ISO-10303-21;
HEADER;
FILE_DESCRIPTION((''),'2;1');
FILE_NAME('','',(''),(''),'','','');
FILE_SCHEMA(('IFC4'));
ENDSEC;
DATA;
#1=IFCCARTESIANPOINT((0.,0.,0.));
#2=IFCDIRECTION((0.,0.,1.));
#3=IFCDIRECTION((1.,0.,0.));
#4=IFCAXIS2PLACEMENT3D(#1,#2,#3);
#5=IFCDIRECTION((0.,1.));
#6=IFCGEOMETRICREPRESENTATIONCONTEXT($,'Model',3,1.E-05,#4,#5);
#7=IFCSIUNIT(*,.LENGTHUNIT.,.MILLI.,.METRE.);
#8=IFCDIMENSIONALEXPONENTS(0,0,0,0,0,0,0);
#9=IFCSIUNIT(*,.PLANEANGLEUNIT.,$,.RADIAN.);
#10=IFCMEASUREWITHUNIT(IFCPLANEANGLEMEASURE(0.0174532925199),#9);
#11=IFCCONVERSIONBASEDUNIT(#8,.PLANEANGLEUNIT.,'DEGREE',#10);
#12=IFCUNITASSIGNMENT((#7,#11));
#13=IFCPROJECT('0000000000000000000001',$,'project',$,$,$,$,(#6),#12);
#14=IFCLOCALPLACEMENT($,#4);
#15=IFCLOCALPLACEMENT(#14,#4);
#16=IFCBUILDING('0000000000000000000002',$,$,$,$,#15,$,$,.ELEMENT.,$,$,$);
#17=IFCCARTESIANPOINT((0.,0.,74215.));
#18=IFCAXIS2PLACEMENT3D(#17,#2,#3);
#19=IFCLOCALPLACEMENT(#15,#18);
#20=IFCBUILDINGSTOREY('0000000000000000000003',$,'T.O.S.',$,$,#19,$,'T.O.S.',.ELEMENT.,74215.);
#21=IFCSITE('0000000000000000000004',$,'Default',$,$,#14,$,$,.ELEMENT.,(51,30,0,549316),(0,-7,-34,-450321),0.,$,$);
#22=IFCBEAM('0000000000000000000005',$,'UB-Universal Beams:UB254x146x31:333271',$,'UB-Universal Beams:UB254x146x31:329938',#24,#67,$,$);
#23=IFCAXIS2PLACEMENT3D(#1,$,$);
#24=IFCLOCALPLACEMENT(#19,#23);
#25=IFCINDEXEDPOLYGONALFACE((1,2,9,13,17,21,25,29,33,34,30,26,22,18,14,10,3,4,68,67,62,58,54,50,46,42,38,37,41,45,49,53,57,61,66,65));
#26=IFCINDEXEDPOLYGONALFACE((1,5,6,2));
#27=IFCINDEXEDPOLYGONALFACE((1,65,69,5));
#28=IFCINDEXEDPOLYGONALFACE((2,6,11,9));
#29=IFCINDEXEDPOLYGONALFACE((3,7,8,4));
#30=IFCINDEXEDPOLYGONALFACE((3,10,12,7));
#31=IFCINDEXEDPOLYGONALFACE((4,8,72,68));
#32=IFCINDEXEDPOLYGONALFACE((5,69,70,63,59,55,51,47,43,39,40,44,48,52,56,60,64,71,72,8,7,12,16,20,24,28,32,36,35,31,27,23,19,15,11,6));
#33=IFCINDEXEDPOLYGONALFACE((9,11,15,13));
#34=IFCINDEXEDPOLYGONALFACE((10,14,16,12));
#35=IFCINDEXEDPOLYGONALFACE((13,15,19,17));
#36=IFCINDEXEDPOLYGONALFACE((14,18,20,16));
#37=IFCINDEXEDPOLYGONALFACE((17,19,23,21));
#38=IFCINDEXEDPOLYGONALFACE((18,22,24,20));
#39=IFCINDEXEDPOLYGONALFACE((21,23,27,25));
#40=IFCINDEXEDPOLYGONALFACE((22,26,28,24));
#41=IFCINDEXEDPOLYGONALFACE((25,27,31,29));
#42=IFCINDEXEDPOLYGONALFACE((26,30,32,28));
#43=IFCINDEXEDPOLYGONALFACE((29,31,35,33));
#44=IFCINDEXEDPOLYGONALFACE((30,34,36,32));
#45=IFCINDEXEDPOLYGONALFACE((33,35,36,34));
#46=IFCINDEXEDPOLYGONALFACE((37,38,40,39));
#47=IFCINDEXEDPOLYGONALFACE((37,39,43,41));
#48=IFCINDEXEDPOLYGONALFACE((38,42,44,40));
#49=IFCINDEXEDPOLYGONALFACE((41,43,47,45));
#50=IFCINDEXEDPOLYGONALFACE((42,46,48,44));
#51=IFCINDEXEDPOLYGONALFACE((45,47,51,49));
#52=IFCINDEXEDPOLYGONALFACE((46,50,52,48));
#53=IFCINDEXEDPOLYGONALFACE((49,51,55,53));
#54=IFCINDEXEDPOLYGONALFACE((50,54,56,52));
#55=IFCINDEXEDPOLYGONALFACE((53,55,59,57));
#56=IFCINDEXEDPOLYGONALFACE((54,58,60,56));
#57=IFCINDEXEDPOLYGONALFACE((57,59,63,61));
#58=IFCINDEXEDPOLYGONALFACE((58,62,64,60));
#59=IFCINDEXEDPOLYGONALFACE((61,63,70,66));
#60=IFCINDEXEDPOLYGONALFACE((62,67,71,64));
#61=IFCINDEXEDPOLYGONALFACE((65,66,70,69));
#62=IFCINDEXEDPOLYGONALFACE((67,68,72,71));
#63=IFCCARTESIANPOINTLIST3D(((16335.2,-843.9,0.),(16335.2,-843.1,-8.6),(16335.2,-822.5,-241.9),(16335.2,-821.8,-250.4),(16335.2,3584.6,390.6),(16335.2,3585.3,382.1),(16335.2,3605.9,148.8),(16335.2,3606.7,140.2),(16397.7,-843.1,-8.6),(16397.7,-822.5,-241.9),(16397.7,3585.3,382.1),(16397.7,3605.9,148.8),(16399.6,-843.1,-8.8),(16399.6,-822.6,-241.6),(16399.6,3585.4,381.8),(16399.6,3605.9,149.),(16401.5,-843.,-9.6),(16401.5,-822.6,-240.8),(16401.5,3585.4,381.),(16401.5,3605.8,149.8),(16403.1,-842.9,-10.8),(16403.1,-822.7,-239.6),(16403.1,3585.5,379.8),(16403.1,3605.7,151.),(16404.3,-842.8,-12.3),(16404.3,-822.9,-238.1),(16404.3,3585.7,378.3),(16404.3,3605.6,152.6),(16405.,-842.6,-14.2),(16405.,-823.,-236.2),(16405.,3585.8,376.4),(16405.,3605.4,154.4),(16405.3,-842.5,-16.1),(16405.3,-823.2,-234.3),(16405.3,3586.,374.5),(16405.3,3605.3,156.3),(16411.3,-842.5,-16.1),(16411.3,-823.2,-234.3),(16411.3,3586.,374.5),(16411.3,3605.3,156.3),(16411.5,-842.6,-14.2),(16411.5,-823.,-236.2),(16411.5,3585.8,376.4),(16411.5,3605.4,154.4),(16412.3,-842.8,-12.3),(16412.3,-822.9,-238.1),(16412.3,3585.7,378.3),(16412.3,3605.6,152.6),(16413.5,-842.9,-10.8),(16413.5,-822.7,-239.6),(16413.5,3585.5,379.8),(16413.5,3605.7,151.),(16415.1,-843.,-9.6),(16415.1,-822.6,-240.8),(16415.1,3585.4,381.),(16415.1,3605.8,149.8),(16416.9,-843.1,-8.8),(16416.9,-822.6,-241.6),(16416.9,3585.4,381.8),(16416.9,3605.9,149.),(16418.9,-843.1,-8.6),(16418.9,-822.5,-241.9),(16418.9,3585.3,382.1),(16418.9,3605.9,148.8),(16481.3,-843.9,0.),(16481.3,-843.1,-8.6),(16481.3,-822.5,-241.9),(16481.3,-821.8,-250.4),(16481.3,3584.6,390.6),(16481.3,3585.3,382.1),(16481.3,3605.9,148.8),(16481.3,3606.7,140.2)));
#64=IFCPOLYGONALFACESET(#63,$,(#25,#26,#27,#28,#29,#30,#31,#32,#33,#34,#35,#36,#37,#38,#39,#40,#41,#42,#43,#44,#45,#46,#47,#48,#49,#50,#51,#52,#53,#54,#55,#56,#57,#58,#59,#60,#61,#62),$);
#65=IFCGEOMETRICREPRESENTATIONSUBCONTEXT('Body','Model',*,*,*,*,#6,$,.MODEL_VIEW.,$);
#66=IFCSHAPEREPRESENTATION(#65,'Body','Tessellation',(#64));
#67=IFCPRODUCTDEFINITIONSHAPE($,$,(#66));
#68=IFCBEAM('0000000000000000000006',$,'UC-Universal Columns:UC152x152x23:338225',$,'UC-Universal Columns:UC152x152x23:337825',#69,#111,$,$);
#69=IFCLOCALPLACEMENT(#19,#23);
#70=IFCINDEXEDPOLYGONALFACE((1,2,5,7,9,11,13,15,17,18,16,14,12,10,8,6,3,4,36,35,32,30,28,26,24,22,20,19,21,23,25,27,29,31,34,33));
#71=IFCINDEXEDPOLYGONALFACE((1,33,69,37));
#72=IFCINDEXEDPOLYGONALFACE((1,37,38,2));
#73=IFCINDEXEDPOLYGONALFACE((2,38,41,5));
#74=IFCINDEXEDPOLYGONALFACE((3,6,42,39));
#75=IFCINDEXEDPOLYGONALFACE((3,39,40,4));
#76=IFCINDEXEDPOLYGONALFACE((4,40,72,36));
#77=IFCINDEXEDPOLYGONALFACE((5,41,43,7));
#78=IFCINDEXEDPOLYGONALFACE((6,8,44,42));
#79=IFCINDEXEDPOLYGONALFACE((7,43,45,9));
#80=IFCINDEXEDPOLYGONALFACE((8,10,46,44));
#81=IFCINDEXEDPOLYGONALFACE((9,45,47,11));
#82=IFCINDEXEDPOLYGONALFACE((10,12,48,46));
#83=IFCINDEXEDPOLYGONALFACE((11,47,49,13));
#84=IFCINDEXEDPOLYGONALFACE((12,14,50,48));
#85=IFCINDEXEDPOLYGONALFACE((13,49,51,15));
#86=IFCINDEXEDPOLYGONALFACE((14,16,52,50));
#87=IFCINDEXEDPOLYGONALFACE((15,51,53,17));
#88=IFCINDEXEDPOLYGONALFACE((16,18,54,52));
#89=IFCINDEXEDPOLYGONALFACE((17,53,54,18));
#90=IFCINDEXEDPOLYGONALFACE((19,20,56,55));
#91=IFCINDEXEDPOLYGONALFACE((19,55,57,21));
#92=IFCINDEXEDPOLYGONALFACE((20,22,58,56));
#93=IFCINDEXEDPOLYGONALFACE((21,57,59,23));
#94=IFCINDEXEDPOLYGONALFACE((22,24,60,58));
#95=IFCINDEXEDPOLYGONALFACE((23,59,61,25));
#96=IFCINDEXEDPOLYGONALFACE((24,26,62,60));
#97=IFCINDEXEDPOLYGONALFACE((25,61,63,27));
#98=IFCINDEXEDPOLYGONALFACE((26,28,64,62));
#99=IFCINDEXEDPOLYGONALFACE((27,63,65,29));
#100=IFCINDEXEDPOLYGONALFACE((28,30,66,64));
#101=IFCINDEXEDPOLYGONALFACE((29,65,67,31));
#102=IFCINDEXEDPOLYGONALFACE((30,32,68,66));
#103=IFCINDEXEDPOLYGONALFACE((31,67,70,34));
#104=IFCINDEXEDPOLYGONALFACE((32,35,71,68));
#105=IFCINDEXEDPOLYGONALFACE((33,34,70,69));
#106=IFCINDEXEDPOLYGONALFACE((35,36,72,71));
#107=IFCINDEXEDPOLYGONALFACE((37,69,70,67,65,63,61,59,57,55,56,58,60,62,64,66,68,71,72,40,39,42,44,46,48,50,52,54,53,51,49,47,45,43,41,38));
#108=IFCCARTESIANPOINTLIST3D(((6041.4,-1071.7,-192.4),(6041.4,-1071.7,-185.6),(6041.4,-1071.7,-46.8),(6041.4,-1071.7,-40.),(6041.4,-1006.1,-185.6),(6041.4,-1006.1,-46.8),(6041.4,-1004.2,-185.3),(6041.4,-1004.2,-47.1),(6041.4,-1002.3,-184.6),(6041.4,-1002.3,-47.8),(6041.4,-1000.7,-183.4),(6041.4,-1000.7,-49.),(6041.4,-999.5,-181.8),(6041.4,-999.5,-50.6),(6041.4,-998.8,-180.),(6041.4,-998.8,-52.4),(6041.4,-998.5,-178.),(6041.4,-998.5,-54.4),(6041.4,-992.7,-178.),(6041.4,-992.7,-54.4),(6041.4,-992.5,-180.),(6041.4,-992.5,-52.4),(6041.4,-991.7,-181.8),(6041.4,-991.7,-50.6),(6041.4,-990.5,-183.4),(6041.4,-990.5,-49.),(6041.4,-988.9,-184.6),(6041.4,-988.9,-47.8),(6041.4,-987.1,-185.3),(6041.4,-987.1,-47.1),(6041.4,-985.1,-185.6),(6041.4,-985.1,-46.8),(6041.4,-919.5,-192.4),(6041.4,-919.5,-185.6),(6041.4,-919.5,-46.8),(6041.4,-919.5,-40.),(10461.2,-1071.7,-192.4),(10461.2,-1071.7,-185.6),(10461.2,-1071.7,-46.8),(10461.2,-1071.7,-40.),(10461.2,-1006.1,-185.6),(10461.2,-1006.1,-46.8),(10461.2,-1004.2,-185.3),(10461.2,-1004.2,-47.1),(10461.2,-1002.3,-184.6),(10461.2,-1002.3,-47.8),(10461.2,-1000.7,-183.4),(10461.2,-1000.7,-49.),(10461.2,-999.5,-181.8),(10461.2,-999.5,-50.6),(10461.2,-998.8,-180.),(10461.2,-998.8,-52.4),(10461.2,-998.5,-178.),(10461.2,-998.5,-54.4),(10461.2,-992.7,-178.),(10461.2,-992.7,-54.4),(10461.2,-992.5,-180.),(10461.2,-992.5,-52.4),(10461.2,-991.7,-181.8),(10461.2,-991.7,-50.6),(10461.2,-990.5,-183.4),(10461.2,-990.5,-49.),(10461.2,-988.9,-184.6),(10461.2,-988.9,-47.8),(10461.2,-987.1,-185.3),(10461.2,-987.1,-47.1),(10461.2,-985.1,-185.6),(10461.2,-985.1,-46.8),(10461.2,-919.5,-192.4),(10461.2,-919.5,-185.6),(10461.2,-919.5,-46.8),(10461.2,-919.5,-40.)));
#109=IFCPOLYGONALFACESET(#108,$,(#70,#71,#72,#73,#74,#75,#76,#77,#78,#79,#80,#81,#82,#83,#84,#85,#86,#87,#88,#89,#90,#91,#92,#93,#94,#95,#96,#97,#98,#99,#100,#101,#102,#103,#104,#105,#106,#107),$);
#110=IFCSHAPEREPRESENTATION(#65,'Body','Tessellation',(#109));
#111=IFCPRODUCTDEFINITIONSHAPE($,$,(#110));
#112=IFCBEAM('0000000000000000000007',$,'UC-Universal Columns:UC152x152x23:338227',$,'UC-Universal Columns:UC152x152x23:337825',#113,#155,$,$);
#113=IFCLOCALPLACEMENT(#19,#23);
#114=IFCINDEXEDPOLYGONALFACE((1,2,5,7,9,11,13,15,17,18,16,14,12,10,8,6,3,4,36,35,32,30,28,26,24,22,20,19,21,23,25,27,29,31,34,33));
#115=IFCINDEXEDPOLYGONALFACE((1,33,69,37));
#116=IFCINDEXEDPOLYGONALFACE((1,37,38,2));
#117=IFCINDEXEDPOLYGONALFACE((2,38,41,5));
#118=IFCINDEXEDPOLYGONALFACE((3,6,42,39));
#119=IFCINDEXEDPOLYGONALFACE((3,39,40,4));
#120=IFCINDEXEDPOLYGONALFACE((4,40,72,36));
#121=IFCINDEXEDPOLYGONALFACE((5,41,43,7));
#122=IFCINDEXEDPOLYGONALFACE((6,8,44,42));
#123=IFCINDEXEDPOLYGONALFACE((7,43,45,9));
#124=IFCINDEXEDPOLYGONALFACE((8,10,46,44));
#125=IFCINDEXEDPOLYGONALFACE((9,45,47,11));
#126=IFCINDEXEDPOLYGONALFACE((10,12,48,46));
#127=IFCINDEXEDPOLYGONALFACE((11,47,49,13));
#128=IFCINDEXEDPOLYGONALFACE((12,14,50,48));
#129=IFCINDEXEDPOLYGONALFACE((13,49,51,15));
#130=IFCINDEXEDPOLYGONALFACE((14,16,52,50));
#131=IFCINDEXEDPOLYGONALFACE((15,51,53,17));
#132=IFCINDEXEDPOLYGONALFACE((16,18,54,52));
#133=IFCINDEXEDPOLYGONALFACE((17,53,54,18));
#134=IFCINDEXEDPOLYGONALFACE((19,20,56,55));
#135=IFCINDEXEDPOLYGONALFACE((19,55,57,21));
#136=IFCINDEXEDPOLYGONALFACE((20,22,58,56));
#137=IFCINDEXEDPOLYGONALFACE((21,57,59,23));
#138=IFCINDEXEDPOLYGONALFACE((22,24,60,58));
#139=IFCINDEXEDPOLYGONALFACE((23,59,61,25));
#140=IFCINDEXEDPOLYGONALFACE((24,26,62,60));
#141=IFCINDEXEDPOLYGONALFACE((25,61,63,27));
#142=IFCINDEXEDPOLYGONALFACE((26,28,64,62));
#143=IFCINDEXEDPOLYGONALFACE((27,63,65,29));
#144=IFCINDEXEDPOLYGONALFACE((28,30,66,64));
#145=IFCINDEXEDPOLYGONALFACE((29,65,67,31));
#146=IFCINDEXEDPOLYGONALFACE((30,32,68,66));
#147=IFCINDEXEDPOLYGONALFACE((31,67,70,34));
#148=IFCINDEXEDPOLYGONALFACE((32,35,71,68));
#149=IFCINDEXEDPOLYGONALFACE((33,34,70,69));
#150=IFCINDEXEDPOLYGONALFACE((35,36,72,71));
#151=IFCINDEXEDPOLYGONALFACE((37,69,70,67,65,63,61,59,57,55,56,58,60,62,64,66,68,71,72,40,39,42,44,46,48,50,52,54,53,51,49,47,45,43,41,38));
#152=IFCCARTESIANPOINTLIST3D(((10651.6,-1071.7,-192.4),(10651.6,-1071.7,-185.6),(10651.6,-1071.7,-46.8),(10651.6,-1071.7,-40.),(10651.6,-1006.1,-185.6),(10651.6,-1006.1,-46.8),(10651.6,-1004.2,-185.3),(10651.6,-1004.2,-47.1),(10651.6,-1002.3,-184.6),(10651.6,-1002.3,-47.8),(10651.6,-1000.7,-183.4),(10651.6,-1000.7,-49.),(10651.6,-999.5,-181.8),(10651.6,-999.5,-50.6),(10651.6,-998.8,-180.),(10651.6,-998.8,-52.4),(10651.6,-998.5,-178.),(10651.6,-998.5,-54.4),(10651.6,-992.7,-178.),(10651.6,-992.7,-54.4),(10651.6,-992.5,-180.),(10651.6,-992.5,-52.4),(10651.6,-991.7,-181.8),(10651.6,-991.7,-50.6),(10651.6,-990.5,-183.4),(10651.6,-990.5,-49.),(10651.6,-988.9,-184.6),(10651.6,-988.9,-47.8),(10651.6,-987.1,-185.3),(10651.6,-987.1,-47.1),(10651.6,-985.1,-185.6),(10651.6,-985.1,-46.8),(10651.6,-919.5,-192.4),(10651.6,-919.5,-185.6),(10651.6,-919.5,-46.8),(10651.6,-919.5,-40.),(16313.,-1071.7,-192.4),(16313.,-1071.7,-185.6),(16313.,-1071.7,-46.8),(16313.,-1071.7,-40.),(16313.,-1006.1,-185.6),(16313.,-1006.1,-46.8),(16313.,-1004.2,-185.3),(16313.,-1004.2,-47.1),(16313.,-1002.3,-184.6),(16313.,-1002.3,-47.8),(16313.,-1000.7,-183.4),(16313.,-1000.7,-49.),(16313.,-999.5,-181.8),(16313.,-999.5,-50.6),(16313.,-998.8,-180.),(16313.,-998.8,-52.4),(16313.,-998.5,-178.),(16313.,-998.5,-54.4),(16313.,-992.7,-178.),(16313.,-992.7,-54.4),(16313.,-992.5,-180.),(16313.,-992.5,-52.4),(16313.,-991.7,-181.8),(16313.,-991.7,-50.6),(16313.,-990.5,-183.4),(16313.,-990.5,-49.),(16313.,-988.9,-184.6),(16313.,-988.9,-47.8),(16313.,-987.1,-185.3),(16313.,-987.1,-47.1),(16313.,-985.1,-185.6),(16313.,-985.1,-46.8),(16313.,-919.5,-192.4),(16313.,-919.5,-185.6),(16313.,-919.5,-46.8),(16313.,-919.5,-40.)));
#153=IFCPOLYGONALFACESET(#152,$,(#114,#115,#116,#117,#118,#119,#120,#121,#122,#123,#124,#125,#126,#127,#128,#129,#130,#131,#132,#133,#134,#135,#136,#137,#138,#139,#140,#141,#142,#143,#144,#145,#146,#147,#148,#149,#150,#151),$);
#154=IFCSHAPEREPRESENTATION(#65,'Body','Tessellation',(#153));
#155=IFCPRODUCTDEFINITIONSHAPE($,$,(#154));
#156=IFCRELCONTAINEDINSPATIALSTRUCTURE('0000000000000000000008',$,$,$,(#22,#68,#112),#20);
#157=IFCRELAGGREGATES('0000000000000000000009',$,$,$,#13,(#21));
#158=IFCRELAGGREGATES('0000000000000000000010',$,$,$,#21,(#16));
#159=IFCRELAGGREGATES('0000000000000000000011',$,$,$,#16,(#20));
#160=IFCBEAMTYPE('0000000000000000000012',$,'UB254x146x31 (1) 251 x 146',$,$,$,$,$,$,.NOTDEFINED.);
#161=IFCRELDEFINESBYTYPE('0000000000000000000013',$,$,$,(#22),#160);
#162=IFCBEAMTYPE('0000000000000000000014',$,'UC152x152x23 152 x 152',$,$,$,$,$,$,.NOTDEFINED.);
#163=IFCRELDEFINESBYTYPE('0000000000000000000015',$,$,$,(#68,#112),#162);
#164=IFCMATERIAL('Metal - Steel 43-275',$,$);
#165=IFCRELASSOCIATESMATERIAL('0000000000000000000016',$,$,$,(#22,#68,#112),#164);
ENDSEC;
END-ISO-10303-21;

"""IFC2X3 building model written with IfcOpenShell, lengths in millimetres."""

from ifc_helpers import new_model, entity, si_unit, converted_unit, point, direction, frame, frame_2d, origin_with_axes, place, context, subcontext, project, spatial, polyline, circle_curve, parameter, trimmed, segment, composite_curve, outline, extrude, clip, halfspace, material, type_object, element, save


model = new_model("IFC2X3")

# Units and contexts
model_context = context("Model", 3, precision=1e-05, world=origin_with_axes(), true_north=direction((0.0, 1.0)))
body_context = subcontext(model_context, "Body", "Model", "MODEL_VIEW")
ifc_project = project(units=[si_unit("LENGTHUNIT", "METRE", prefix="MILLI"), converted_unit("PLANEANGLEUNIT", "DEGREE", entity("IfcPlaneAngleMeasure", 0.0174532925199), si_unit("PLANEANGLEUNIT", "RADIAN"), dimensions=[0, 0, 0, 0, 0, 0, 0])], contexts=[model_context])

# Site, building, storey
site_placement = place(None, origin_with_axes())
site = spatial("IfcSite", under=ifc_project, at=site_placement, Name="Default", CompositionType="ELEMENT", RefLatitude=(51, 30, 0, 549316), RefLongitude=(0, -7, -34, -450321), RefElevation=0.0)
building_placement = place(site_placement, origin_with_axes())
building = spatial("IfcBuilding", under=site, at=building_placement, CompositionType="ELEMENT")
storey_placement = place(building_placement, frame((0.0, 0.0, 74215.0), z_axis=(0.0, 0.0, 1.0), x_axis=(1.0, 0.0, 0.0)))
storey = spatial("IfcBuildingStorey", under=building, at=storey_placement, Name="T.O.S.", LongName="T.O.S.", CompositionType="ELEMENT", Elevation=74215.0)

# Beams
ifc_material = material(Name="Metal - Steel 43-275")
beam_type_1 = type_object("IfcBeamType", Name="UB254x146x31 (1) 251 x 146", PredefinedType="NOTDEFINED")
beam_1_placement = place(storey_placement, frame((16408.3, 3613.8, 267.0), z_axis=(0.0, 0.0, 1.0), x_axis=(-1.0, 0.0, 0.0)))
element("IfcBeam", 1, at=beam_1_placement, inside=storey, type_object=beam_type_1, material=ifc_material, Name="UB-Universal Beams:UB254x146x31:333271", ObjectType="UB-Universal Beams:UB254x146x31:329938", context=body_context, shape_type="Clipping", body=[
    clip(clip(clip(clip(extrude(outline(composite_curve([segment(polyline([(125.7, 73.0), (117.1, 73.0), (117.1, 10.6)]), True, "CONTINUOUS"), segment(trimmed(circle_curve(frame_2d((109.5, 10.6), x_axis=(0.0, -1.0)), 7.6), [point((117.1, 10.6)), parameter(90.0)], [point((109.5, 3.0)), parameter(0.0)], False, "CARTESIAN"), True, "CONTINUOUS"), segment(polyline([(109.5, 3.0), (-109.5, 3.0)]), True, "CONTINUOUS"), segment(trimmed(circle_curve(frame_2d((-109.5, 10.6), x_axis=(-1.0, 0.0)), 7.6), [point((-109.5, 3.0)), parameter(90.0)], [point((-117.1, 10.6)), parameter(0.0)], False, "CARTESIAN"), True, "CONTINUOUS"), segment(polyline([(-117.1, 10.6), (-117.1, 73.0), (-125.7, 73.0), (-125.7, -73.0), (-117.1, -73.0), (-117.1, -10.6)]), True, "CONTINUOUS"), segment(trimmed(circle_curve(frame_2d((-109.5, -10.6), x_axis=(0.0, 1.0)), 7.6), [point((-117.1, -10.6)), parameter(90.0)], [point((-109.5, -3.0)), parameter(0.0)], False, "CARTESIAN"), True, "CONTINUOUS"), segment(polyline([(-109.5, -3.0), (109.5, -3.0)]), True, "CONTINUOUS"), segment(trimmed(circle_curve(frame_2d((109.5, -10.6), x_axis=(1.0, 0.0)), 7.6), [point((109.5, -3.0)), parameter(90.0)], [point((117.1, -10.6)), parameter(0.0)], False, "CARTESIAN"), True, "CONTINUOUS"), segment(polyline([(117.1, -10.6), (117.1, -73.0), (125.7, -73.0), (125.7, 73.0)]), True, "CONTINUOUS")], self_intersect=False)), frame((0.0, 4482.9, -395.4), z_axis=(0.0, -0.996132, 0.087866), x_axis=(0.0, -0.087866, -0.996132)), (0.0, 0.0, 1.0), 4518.6), halfspace(frame((0.0, 4446.6, -392.2), z_axis=(0.0, -0.996132, 0.087866), x_axis=(0.0, -0.087866, -0.996132)), True)), halfspace(frame((0.0, 18.2, -1.6), z_axis=(0.0, 0.996132, -0.087866), x_axis=(0.0, 0.087866, 0.996132)), True)), halfspace(frame((0.0, 4464.8, 0.0), z_axis=(0.0, -1.0, 0.0), x_axis=(0.0, 0.0, -1.0)), True)), halfspace(frame((0.0, 0.0, 0.0), z_axis=(0.0, 1.0, 0.0), x_axis=(0.0, 0.0, 1.0)), True)),
])
beam_type_2 = type_object("IfcBeamType", Name="UC152x152x23 152 x 152", PredefinedType="NOTDEFINED")
beam_2_placement = place(storey_placement, frame((10461.2, -995.6, -116.2), z_axis=(0.0, 0.0, 1.0), x_axis=(0.0, 1.0, 0.0)))
element("IfcBeam", 2, at=beam_2_placement, inside=storey, type_object=beam_type_2, material=ifc_material, Name="UC-Universal Columns:UC152x152x23:338225", ObjectType="UC-Universal Columns:UC152x152x23:337825", context=body_context, shape_type="SweptSolid", body=[
    extrude(outline(composite_curve([segment(polyline([(76.2, 76.1), (69.4, 76.1), (69.4, 10.5)]), True, "CONTINUOUS"), segment(trimmed(circle_curve(frame_2d((61.8, 10.5), x_axis=(0.0, -1.0)), 7.6), [point((69.4, 10.5)), parameter(90.0)], [point((61.8, 2.9)), parameter(0.0)], False, "CARTESIAN"), True, "CONTINUOUS"), segment(polyline([(61.8, 2.9), (-61.8, 2.9)]), True, "CONTINUOUS"), segment(trimmed(circle_curve(frame_2d((-61.8, 10.5), x_axis=(-1.0, 0.0)), 7.6), [point((-61.8, 2.9)), parameter(90.0)], [point((-69.4, 10.5)), parameter(0.0)], False, "CARTESIAN"), True, "CONTINUOUS"), segment(polyline([(-69.4, 10.5), (-69.4, 76.1), (-76.2, 76.1), (-76.2, -76.1), (-69.4, -76.1), (-69.4, -10.5)]), True, "CONTINUOUS"), segment(trimmed(circle_curve(frame_2d((-61.8, -10.5), x_axis=(0.0, 1.0)), 7.6), [point((-69.4, -10.5)), parameter(90.0)], [point((-61.8, -2.9)), parameter(0.0)], False, "CARTESIAN"), True, "CONTINUOUS"), segment(polyline([(-61.8, -2.9), (61.8, -2.9)]), True, "CONTINUOUS"), segment(trimmed(circle_curve(frame_2d((61.8, -10.5), x_axis=(1.0, 0.0)), 7.6), [point((61.8, -2.9)), parameter(90.0)], [point((69.4, -10.5)), parameter(0.0)], False, "CARTESIAN"), True, "CONTINUOUS"), segment(polyline([(69.4, -10.5), (69.4, -76.1), (76.2, -76.1), (76.2, 76.1)]), True, "CONTINUOUS")], self_intersect=False)), frame((0.0, 4419.8, 0.0), z_axis=(0.0, -1.0, 0.0), x_axis=(0.0, 0.0, -1.0)), (0.0, 0.0, 1.0), 4419.8),
])
beam_3_placement = place(storey_placement, frame((16313.0, -995.6, -116.2), z_axis=(0.0, 0.0, 1.0), x_axis=(0.0, 1.0, 0.0)))
element("IfcBeam", 3, at=beam_3_placement, inside=storey, type_object=beam_type_2, material=ifc_material, Name="UC-Universal Columns:UC152x152x23:338227", ObjectType="UC-Universal Columns:UC152x152x23:337825", context=body_context, shape_type="SweptSolid", body=[
    extrude(outline(composite_curve([segment(polyline([(76.2, 76.1), (69.4, 76.1), (69.4, 10.5)]), True, "CONTINUOUS"), segment(trimmed(circle_curve(frame_2d((61.8, 10.5), x_axis=(0.0, -1.0)), 7.6), [point((69.4, 10.5)), parameter(90.0)], [point((61.8, 2.9)), parameter(0.0)], False, "CARTESIAN"), True, "CONTINUOUS"), segment(polyline([(61.8, 2.9), (-61.8, 2.9)]), True, "CONTINUOUS"), segment(trimmed(circle_curve(frame_2d((-61.8, 10.5), x_axis=(-1.0, 0.0)), 7.6), [point((-61.8, 2.9)), parameter(90.0)], [point((-69.4, 10.5)), parameter(0.0)], False, "CARTESIAN"), True, "CONTINUOUS"), segment(polyline([(-69.4, 10.5), (-69.4, 76.1), (-76.2, 76.1), (-76.2, -76.1), (-69.4, -76.1), (-69.4, -10.5)]), True, "CONTINUOUS"), segment(trimmed(circle_curve(frame_2d((-61.8, -10.5), x_axis=(0.0, 1.0)), 7.6), [point((-69.4, -10.5)), parameter(90.0)], [point((-61.8, -2.9)), parameter(0.0)], False, "CARTESIAN"), True, "CONTINUOUS"), segment(polyline([(-61.8, -2.9), (61.8, -2.9)]), True, "CONTINUOUS"), segment(trimmed(circle_curve(frame_2d((61.8, -10.5), x_axis=(1.0, 0.0)), 7.6), [point((61.8, -2.9)), parameter(90.0)], [point((69.4, -10.5)), parameter(0.0)], False, "CARTESIAN"), True, "CONTINUOUS"), segment(polyline([(69.4, -10.5), (69.4, -76.1), (76.2, -76.1), (76.2, 76.1)]), True, "CONTINUOUS")], self_intersect=False)), frame((0.0, 5661.4, 0.0), z_axis=(0.0, -1.0, 0.0), x_axis=(0.0, 0.0, -1.0)), (0.0, 0.0, 1.0), 5661.4),
])

save(model, "model.ifc")
